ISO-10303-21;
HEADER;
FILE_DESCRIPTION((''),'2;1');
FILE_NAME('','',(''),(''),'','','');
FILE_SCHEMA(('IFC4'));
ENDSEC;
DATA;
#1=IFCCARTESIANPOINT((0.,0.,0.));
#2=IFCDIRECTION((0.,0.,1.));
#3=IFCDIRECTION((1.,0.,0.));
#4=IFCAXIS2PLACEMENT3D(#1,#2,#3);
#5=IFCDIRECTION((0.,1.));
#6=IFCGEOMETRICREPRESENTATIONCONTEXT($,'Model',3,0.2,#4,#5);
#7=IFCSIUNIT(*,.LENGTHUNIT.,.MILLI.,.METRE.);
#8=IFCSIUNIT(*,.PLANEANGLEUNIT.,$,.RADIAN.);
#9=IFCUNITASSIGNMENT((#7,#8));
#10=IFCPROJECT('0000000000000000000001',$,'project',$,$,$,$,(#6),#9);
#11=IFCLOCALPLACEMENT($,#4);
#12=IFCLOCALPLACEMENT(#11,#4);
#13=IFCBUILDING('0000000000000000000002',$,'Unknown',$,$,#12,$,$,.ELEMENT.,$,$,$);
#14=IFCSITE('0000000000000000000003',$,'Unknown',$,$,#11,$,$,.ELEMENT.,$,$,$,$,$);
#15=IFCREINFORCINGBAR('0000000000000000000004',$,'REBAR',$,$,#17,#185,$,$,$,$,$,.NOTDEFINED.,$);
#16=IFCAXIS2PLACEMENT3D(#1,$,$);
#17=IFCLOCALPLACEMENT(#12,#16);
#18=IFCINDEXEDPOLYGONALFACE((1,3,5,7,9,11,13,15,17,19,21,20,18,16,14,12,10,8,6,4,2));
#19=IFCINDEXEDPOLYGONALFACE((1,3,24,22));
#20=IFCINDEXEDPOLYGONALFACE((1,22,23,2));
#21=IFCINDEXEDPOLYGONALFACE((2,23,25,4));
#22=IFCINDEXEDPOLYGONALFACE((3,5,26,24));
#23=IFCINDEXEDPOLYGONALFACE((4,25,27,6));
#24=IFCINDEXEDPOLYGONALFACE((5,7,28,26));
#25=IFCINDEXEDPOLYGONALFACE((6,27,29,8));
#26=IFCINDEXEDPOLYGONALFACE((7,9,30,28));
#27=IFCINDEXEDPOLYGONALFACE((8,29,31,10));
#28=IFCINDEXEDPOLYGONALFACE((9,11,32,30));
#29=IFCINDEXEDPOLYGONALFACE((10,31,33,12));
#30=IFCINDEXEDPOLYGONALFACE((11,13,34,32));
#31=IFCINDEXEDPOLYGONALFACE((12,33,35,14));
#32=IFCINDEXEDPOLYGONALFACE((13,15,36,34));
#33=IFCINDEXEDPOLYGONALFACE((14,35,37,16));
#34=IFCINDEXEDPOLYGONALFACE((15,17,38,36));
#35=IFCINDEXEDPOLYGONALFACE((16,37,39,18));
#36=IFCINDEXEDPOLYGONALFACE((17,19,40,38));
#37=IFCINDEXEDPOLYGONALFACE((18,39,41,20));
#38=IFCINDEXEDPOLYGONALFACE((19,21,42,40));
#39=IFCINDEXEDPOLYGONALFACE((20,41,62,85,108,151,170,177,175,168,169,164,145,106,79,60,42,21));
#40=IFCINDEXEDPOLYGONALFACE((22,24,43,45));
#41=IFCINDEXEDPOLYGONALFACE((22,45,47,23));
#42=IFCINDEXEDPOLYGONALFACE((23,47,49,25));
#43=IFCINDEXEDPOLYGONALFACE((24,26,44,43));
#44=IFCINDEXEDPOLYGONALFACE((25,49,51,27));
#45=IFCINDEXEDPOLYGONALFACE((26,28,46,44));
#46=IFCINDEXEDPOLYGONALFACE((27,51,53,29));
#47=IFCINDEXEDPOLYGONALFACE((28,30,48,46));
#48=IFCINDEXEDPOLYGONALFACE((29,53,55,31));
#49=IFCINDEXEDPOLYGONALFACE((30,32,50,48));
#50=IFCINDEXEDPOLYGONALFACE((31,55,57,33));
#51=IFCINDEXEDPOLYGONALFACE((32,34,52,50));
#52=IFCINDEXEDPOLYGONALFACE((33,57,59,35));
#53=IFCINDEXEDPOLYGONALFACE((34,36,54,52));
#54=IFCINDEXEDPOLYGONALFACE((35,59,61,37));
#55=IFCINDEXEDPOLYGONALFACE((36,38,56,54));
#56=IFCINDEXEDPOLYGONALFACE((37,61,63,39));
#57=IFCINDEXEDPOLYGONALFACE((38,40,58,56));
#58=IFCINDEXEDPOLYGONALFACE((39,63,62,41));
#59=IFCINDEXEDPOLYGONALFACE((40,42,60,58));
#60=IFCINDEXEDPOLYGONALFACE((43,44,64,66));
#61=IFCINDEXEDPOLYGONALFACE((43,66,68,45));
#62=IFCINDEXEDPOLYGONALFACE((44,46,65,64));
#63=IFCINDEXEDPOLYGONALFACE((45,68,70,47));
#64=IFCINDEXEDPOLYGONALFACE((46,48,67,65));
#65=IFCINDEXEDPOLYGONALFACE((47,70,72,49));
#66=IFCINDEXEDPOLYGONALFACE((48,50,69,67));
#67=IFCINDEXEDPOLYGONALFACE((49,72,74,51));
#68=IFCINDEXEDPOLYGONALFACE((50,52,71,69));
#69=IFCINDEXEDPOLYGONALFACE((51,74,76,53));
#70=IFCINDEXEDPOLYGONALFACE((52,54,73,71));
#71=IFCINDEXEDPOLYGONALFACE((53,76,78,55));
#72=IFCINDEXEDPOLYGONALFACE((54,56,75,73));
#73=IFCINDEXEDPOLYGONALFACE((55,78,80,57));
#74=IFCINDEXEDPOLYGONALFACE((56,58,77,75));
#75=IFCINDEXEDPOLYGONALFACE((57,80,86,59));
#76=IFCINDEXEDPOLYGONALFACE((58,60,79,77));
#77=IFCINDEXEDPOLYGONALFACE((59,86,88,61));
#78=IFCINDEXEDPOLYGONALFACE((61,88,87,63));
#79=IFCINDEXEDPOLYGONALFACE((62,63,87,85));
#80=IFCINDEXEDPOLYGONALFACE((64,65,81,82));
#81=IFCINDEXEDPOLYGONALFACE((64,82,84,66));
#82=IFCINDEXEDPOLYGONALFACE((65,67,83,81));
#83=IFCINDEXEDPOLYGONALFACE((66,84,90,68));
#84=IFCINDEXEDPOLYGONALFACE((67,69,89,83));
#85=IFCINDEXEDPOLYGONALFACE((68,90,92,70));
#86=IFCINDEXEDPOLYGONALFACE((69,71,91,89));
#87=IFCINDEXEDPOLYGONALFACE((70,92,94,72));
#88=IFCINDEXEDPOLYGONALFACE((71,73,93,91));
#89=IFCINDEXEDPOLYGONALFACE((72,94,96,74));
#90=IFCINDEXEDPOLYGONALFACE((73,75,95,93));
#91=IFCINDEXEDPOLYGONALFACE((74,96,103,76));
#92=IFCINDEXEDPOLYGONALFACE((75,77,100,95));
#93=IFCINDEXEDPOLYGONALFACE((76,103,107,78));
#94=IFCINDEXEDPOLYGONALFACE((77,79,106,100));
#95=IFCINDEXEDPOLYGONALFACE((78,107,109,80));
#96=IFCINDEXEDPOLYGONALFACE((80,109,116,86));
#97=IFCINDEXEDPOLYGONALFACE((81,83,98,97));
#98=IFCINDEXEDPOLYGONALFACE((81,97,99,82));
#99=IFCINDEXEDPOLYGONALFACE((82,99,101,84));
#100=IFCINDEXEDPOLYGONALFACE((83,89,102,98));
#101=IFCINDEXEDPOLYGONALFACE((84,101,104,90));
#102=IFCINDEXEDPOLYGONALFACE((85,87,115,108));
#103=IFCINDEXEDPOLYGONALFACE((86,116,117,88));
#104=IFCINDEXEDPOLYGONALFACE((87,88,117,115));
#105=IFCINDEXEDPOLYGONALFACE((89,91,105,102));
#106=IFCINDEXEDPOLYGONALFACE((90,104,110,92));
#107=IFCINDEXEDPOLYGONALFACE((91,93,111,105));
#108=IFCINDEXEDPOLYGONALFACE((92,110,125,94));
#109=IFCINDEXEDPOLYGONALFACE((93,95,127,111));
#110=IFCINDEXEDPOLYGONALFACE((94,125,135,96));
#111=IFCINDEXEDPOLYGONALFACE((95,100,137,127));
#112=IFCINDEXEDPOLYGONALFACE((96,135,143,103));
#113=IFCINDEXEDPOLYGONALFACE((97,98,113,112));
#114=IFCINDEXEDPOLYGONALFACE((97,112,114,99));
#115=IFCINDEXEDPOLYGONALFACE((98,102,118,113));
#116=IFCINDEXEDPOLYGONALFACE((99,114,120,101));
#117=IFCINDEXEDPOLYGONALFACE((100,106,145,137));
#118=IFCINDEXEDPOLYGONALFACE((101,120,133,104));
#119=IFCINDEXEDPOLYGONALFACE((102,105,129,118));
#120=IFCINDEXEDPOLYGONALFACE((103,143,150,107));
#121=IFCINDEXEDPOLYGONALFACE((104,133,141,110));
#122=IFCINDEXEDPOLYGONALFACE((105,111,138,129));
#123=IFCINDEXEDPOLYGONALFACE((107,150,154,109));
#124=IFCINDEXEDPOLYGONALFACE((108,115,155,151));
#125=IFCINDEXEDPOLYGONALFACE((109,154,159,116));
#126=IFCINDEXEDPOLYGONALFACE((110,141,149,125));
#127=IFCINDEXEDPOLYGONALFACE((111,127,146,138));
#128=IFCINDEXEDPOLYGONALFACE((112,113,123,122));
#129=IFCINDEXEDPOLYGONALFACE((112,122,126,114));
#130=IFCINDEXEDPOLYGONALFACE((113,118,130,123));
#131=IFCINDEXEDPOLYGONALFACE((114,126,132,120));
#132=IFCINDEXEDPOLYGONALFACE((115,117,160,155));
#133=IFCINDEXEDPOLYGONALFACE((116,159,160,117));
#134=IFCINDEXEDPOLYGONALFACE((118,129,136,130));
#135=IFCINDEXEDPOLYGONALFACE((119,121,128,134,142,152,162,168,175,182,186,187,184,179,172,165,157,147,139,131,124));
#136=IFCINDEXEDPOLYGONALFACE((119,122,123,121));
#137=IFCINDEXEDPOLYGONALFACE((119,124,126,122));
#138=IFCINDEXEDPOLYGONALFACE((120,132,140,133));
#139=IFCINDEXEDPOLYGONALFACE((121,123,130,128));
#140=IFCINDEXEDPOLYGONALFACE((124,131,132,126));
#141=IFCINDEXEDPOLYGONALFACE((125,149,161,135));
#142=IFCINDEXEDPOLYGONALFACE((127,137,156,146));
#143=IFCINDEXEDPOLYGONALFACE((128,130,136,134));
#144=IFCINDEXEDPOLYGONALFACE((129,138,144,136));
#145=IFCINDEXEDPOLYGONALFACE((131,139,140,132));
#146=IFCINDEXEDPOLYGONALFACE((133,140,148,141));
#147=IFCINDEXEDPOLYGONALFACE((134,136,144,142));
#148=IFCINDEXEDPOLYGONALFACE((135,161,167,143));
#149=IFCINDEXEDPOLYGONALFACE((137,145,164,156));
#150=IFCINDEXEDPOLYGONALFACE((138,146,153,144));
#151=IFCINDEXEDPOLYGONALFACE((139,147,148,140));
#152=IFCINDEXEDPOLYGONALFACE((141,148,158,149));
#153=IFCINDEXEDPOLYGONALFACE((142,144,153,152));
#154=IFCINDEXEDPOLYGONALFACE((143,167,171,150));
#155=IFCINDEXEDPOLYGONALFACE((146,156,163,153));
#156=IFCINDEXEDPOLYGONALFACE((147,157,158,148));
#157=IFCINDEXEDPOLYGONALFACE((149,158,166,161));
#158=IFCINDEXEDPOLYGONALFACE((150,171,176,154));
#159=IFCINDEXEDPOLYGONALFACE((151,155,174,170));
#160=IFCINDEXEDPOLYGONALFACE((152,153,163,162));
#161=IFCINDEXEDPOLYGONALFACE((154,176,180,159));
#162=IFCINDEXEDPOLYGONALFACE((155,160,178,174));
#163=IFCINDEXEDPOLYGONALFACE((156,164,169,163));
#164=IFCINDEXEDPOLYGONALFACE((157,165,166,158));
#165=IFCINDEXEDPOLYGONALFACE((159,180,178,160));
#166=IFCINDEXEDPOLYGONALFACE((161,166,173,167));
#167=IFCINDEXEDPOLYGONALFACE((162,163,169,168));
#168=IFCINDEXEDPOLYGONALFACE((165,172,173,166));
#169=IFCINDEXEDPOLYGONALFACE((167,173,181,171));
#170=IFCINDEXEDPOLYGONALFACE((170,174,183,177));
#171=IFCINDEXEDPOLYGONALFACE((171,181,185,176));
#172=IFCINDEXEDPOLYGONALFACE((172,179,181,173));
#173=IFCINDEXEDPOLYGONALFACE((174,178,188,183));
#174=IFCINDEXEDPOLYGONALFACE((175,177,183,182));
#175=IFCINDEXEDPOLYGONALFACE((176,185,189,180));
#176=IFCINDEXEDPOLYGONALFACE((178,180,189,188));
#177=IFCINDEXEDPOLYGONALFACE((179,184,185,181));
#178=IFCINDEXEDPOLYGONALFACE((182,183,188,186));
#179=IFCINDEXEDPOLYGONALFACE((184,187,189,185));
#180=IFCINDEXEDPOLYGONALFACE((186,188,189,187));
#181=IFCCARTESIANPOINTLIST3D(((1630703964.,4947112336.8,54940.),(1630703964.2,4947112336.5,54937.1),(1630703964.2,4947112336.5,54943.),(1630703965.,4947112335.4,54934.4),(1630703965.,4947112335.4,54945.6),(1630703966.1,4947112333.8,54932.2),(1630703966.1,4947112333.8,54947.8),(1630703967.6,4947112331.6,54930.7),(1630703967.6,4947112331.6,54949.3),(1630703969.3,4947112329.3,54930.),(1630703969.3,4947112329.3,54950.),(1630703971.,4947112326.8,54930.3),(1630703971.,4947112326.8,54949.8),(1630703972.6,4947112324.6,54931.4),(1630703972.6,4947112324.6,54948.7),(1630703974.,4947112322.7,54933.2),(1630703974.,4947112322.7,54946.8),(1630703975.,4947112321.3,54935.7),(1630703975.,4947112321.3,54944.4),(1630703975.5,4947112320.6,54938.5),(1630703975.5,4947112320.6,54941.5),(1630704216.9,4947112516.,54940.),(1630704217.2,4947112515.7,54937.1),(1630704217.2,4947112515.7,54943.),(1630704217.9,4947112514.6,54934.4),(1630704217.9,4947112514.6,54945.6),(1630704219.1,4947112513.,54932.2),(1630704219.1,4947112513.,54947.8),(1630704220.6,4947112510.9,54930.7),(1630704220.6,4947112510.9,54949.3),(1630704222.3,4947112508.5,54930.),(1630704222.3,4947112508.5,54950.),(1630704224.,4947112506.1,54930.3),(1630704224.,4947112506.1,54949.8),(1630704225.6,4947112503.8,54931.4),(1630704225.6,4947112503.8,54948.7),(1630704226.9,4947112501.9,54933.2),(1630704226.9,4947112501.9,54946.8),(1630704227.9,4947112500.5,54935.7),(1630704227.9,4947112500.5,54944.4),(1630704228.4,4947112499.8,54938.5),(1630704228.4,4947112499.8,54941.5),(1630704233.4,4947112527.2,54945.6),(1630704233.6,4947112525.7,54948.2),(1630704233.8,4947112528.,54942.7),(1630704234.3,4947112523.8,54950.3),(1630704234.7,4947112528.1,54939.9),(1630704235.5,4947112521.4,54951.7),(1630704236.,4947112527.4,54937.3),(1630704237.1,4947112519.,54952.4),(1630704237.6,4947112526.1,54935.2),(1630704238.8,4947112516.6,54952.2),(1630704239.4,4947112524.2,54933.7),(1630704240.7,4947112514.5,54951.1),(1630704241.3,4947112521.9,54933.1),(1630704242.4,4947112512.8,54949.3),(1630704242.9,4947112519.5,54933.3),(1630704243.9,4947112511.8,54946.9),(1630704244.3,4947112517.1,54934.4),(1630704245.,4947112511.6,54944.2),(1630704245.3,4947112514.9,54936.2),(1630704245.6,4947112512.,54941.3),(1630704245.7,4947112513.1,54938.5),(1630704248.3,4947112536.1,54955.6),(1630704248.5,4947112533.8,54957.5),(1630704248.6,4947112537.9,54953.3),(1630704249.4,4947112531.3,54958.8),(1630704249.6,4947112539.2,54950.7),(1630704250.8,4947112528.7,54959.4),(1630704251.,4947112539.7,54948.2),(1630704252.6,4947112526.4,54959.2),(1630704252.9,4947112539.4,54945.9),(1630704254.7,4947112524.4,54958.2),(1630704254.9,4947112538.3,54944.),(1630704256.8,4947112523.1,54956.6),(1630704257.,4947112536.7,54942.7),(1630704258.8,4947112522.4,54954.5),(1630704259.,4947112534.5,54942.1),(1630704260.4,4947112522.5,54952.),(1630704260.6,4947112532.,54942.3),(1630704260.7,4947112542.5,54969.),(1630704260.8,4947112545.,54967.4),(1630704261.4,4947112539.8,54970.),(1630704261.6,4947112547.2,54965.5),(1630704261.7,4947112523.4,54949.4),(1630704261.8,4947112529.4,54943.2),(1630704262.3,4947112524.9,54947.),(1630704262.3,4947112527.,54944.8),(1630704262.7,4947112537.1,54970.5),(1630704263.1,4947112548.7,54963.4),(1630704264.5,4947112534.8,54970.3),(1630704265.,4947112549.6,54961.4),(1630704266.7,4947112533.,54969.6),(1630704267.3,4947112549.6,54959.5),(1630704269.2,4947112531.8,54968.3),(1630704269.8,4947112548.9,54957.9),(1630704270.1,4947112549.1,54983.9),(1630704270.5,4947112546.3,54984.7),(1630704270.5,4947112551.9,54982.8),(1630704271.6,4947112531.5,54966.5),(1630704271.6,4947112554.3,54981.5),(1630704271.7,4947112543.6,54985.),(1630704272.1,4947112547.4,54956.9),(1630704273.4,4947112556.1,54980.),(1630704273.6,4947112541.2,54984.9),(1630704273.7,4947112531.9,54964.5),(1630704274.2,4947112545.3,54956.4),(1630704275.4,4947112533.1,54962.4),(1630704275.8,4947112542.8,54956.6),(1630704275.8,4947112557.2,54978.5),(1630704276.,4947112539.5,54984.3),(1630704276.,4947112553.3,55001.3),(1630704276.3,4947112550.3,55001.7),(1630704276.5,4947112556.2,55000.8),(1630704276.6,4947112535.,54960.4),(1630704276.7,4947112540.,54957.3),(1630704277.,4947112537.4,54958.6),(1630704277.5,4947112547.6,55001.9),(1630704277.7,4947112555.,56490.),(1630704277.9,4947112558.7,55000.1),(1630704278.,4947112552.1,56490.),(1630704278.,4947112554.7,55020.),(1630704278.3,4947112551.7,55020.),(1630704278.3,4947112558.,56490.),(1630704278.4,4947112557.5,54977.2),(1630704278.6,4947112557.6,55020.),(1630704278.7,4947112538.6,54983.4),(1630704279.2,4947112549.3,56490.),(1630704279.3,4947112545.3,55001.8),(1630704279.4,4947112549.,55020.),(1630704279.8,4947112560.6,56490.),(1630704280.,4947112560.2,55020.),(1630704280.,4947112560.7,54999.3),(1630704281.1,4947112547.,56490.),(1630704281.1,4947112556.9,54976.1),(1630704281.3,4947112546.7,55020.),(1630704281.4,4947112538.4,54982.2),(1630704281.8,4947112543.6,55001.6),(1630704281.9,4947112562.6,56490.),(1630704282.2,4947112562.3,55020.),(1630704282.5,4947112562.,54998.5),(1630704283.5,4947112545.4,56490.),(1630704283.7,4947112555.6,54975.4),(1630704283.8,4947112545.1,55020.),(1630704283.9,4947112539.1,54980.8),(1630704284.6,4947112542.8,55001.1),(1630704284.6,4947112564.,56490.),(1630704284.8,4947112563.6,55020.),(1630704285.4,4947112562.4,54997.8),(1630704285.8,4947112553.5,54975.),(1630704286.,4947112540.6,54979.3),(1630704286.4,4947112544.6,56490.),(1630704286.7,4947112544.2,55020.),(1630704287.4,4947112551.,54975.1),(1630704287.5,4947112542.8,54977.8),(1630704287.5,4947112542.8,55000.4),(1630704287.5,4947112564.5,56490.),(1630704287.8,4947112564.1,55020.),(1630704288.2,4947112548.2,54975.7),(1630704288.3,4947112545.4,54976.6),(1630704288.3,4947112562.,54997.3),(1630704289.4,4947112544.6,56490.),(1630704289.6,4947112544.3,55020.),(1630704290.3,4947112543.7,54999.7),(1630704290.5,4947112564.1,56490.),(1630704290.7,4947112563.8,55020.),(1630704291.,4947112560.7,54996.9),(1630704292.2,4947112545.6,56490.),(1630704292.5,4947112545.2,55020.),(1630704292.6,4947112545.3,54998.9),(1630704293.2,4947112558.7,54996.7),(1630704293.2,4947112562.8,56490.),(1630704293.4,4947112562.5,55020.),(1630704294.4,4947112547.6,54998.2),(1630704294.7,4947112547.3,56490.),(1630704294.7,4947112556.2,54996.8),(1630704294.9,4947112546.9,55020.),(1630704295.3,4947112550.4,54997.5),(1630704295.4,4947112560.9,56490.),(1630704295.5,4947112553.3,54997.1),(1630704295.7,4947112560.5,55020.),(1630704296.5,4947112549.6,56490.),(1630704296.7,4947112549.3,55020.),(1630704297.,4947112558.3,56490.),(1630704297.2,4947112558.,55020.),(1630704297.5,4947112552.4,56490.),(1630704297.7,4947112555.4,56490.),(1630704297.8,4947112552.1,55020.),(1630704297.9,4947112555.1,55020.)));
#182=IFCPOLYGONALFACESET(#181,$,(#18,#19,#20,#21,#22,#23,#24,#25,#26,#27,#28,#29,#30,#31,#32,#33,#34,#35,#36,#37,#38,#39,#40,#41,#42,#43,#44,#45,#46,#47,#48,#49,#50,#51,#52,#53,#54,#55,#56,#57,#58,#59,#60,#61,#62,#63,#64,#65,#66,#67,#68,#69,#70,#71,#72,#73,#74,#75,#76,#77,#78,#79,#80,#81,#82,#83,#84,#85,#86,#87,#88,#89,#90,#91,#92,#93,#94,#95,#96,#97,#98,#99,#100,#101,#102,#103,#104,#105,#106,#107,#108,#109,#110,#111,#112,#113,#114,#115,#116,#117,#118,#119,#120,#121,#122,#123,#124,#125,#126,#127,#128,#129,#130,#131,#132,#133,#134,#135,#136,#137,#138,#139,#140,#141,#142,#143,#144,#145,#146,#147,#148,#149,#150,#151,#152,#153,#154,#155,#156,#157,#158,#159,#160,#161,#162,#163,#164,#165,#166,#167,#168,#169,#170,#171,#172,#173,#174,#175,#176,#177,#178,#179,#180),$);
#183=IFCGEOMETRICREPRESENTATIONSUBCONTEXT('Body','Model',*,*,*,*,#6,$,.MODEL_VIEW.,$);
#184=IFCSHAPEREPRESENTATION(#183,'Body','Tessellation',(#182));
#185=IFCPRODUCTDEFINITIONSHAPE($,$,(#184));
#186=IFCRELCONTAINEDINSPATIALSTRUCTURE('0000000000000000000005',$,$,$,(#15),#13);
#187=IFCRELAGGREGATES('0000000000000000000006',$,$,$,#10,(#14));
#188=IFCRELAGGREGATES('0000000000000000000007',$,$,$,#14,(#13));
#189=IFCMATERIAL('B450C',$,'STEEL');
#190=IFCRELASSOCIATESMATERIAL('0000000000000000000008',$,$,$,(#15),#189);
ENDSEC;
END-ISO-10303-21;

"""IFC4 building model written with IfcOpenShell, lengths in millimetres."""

from ifc_helpers import new_model, entity, si_unit, direction, frame, origin_with_axes, place, context, subcontext, project, spatial, material, element, save


model = new_model("IFC4")

# Units and contexts
model_context = context("Model", 3, precision=0.2, world=origin_with_axes(), true_north=direction((0.0, 1.0)))
body_context = subcontext(model_context, "Body", "Model", "MODEL_VIEW")
ifc_project = project(units=[si_unit("LENGTHUNIT", "METRE", prefix="MILLI"), si_unit("PLANEANGLEUNIT", "RADIAN")], contexts=[model_context])

# Site, building
site_placement = place(None, origin_with_axes())
site = spatial("IfcSite", under=ifc_project, at=site_placement, Name="Unknown", CompositionType="ELEMENT")
building_placement = place(site_placement, origin_with_axes())
building = spatial("IfcBuilding", under=site, at=building_placement, Name="Unknown", CompositionType="ELEMENT")

# Reinforcing bar
ifc_material = material(Name="B450C", Category="STEEL")
reinforcing_bar_1_placement = place(building_placement, frame((1630704299.9, 4947112623.8, 54890.0), z_axis=(0.5781, -0.815966, 0.0), x_axis=(0.0, 0.0, 1.0)))
element("IfcReinforcingBar", 1, at=reinforcing_bar_1_placement, inside=building, material=ifc_material, Name="REBAR", PredefinedType="NOTDEFINED", context=body_context, shape_type="AdvancedSweptSolid", body=[
    entity("IfcSweptDiskSolid", entity("IfcIndexedPolyCurve", entity("IfcCartesianPointList3D", [[50.0, 440.0, 50.0], [50.0, 130.0, 50.0], [73.4, 73.4, 50.0], [130.0, 50.0, 50.0], [1600.0, 50.0, 49.5]]), [entity("IfcLineIndex", [1, 2]), entity("IfcArcIndex", [2, 3, 4]), entity("IfcLineIndex", [4, 5])]), 10.0),
])

save(model, "model.ifc")
